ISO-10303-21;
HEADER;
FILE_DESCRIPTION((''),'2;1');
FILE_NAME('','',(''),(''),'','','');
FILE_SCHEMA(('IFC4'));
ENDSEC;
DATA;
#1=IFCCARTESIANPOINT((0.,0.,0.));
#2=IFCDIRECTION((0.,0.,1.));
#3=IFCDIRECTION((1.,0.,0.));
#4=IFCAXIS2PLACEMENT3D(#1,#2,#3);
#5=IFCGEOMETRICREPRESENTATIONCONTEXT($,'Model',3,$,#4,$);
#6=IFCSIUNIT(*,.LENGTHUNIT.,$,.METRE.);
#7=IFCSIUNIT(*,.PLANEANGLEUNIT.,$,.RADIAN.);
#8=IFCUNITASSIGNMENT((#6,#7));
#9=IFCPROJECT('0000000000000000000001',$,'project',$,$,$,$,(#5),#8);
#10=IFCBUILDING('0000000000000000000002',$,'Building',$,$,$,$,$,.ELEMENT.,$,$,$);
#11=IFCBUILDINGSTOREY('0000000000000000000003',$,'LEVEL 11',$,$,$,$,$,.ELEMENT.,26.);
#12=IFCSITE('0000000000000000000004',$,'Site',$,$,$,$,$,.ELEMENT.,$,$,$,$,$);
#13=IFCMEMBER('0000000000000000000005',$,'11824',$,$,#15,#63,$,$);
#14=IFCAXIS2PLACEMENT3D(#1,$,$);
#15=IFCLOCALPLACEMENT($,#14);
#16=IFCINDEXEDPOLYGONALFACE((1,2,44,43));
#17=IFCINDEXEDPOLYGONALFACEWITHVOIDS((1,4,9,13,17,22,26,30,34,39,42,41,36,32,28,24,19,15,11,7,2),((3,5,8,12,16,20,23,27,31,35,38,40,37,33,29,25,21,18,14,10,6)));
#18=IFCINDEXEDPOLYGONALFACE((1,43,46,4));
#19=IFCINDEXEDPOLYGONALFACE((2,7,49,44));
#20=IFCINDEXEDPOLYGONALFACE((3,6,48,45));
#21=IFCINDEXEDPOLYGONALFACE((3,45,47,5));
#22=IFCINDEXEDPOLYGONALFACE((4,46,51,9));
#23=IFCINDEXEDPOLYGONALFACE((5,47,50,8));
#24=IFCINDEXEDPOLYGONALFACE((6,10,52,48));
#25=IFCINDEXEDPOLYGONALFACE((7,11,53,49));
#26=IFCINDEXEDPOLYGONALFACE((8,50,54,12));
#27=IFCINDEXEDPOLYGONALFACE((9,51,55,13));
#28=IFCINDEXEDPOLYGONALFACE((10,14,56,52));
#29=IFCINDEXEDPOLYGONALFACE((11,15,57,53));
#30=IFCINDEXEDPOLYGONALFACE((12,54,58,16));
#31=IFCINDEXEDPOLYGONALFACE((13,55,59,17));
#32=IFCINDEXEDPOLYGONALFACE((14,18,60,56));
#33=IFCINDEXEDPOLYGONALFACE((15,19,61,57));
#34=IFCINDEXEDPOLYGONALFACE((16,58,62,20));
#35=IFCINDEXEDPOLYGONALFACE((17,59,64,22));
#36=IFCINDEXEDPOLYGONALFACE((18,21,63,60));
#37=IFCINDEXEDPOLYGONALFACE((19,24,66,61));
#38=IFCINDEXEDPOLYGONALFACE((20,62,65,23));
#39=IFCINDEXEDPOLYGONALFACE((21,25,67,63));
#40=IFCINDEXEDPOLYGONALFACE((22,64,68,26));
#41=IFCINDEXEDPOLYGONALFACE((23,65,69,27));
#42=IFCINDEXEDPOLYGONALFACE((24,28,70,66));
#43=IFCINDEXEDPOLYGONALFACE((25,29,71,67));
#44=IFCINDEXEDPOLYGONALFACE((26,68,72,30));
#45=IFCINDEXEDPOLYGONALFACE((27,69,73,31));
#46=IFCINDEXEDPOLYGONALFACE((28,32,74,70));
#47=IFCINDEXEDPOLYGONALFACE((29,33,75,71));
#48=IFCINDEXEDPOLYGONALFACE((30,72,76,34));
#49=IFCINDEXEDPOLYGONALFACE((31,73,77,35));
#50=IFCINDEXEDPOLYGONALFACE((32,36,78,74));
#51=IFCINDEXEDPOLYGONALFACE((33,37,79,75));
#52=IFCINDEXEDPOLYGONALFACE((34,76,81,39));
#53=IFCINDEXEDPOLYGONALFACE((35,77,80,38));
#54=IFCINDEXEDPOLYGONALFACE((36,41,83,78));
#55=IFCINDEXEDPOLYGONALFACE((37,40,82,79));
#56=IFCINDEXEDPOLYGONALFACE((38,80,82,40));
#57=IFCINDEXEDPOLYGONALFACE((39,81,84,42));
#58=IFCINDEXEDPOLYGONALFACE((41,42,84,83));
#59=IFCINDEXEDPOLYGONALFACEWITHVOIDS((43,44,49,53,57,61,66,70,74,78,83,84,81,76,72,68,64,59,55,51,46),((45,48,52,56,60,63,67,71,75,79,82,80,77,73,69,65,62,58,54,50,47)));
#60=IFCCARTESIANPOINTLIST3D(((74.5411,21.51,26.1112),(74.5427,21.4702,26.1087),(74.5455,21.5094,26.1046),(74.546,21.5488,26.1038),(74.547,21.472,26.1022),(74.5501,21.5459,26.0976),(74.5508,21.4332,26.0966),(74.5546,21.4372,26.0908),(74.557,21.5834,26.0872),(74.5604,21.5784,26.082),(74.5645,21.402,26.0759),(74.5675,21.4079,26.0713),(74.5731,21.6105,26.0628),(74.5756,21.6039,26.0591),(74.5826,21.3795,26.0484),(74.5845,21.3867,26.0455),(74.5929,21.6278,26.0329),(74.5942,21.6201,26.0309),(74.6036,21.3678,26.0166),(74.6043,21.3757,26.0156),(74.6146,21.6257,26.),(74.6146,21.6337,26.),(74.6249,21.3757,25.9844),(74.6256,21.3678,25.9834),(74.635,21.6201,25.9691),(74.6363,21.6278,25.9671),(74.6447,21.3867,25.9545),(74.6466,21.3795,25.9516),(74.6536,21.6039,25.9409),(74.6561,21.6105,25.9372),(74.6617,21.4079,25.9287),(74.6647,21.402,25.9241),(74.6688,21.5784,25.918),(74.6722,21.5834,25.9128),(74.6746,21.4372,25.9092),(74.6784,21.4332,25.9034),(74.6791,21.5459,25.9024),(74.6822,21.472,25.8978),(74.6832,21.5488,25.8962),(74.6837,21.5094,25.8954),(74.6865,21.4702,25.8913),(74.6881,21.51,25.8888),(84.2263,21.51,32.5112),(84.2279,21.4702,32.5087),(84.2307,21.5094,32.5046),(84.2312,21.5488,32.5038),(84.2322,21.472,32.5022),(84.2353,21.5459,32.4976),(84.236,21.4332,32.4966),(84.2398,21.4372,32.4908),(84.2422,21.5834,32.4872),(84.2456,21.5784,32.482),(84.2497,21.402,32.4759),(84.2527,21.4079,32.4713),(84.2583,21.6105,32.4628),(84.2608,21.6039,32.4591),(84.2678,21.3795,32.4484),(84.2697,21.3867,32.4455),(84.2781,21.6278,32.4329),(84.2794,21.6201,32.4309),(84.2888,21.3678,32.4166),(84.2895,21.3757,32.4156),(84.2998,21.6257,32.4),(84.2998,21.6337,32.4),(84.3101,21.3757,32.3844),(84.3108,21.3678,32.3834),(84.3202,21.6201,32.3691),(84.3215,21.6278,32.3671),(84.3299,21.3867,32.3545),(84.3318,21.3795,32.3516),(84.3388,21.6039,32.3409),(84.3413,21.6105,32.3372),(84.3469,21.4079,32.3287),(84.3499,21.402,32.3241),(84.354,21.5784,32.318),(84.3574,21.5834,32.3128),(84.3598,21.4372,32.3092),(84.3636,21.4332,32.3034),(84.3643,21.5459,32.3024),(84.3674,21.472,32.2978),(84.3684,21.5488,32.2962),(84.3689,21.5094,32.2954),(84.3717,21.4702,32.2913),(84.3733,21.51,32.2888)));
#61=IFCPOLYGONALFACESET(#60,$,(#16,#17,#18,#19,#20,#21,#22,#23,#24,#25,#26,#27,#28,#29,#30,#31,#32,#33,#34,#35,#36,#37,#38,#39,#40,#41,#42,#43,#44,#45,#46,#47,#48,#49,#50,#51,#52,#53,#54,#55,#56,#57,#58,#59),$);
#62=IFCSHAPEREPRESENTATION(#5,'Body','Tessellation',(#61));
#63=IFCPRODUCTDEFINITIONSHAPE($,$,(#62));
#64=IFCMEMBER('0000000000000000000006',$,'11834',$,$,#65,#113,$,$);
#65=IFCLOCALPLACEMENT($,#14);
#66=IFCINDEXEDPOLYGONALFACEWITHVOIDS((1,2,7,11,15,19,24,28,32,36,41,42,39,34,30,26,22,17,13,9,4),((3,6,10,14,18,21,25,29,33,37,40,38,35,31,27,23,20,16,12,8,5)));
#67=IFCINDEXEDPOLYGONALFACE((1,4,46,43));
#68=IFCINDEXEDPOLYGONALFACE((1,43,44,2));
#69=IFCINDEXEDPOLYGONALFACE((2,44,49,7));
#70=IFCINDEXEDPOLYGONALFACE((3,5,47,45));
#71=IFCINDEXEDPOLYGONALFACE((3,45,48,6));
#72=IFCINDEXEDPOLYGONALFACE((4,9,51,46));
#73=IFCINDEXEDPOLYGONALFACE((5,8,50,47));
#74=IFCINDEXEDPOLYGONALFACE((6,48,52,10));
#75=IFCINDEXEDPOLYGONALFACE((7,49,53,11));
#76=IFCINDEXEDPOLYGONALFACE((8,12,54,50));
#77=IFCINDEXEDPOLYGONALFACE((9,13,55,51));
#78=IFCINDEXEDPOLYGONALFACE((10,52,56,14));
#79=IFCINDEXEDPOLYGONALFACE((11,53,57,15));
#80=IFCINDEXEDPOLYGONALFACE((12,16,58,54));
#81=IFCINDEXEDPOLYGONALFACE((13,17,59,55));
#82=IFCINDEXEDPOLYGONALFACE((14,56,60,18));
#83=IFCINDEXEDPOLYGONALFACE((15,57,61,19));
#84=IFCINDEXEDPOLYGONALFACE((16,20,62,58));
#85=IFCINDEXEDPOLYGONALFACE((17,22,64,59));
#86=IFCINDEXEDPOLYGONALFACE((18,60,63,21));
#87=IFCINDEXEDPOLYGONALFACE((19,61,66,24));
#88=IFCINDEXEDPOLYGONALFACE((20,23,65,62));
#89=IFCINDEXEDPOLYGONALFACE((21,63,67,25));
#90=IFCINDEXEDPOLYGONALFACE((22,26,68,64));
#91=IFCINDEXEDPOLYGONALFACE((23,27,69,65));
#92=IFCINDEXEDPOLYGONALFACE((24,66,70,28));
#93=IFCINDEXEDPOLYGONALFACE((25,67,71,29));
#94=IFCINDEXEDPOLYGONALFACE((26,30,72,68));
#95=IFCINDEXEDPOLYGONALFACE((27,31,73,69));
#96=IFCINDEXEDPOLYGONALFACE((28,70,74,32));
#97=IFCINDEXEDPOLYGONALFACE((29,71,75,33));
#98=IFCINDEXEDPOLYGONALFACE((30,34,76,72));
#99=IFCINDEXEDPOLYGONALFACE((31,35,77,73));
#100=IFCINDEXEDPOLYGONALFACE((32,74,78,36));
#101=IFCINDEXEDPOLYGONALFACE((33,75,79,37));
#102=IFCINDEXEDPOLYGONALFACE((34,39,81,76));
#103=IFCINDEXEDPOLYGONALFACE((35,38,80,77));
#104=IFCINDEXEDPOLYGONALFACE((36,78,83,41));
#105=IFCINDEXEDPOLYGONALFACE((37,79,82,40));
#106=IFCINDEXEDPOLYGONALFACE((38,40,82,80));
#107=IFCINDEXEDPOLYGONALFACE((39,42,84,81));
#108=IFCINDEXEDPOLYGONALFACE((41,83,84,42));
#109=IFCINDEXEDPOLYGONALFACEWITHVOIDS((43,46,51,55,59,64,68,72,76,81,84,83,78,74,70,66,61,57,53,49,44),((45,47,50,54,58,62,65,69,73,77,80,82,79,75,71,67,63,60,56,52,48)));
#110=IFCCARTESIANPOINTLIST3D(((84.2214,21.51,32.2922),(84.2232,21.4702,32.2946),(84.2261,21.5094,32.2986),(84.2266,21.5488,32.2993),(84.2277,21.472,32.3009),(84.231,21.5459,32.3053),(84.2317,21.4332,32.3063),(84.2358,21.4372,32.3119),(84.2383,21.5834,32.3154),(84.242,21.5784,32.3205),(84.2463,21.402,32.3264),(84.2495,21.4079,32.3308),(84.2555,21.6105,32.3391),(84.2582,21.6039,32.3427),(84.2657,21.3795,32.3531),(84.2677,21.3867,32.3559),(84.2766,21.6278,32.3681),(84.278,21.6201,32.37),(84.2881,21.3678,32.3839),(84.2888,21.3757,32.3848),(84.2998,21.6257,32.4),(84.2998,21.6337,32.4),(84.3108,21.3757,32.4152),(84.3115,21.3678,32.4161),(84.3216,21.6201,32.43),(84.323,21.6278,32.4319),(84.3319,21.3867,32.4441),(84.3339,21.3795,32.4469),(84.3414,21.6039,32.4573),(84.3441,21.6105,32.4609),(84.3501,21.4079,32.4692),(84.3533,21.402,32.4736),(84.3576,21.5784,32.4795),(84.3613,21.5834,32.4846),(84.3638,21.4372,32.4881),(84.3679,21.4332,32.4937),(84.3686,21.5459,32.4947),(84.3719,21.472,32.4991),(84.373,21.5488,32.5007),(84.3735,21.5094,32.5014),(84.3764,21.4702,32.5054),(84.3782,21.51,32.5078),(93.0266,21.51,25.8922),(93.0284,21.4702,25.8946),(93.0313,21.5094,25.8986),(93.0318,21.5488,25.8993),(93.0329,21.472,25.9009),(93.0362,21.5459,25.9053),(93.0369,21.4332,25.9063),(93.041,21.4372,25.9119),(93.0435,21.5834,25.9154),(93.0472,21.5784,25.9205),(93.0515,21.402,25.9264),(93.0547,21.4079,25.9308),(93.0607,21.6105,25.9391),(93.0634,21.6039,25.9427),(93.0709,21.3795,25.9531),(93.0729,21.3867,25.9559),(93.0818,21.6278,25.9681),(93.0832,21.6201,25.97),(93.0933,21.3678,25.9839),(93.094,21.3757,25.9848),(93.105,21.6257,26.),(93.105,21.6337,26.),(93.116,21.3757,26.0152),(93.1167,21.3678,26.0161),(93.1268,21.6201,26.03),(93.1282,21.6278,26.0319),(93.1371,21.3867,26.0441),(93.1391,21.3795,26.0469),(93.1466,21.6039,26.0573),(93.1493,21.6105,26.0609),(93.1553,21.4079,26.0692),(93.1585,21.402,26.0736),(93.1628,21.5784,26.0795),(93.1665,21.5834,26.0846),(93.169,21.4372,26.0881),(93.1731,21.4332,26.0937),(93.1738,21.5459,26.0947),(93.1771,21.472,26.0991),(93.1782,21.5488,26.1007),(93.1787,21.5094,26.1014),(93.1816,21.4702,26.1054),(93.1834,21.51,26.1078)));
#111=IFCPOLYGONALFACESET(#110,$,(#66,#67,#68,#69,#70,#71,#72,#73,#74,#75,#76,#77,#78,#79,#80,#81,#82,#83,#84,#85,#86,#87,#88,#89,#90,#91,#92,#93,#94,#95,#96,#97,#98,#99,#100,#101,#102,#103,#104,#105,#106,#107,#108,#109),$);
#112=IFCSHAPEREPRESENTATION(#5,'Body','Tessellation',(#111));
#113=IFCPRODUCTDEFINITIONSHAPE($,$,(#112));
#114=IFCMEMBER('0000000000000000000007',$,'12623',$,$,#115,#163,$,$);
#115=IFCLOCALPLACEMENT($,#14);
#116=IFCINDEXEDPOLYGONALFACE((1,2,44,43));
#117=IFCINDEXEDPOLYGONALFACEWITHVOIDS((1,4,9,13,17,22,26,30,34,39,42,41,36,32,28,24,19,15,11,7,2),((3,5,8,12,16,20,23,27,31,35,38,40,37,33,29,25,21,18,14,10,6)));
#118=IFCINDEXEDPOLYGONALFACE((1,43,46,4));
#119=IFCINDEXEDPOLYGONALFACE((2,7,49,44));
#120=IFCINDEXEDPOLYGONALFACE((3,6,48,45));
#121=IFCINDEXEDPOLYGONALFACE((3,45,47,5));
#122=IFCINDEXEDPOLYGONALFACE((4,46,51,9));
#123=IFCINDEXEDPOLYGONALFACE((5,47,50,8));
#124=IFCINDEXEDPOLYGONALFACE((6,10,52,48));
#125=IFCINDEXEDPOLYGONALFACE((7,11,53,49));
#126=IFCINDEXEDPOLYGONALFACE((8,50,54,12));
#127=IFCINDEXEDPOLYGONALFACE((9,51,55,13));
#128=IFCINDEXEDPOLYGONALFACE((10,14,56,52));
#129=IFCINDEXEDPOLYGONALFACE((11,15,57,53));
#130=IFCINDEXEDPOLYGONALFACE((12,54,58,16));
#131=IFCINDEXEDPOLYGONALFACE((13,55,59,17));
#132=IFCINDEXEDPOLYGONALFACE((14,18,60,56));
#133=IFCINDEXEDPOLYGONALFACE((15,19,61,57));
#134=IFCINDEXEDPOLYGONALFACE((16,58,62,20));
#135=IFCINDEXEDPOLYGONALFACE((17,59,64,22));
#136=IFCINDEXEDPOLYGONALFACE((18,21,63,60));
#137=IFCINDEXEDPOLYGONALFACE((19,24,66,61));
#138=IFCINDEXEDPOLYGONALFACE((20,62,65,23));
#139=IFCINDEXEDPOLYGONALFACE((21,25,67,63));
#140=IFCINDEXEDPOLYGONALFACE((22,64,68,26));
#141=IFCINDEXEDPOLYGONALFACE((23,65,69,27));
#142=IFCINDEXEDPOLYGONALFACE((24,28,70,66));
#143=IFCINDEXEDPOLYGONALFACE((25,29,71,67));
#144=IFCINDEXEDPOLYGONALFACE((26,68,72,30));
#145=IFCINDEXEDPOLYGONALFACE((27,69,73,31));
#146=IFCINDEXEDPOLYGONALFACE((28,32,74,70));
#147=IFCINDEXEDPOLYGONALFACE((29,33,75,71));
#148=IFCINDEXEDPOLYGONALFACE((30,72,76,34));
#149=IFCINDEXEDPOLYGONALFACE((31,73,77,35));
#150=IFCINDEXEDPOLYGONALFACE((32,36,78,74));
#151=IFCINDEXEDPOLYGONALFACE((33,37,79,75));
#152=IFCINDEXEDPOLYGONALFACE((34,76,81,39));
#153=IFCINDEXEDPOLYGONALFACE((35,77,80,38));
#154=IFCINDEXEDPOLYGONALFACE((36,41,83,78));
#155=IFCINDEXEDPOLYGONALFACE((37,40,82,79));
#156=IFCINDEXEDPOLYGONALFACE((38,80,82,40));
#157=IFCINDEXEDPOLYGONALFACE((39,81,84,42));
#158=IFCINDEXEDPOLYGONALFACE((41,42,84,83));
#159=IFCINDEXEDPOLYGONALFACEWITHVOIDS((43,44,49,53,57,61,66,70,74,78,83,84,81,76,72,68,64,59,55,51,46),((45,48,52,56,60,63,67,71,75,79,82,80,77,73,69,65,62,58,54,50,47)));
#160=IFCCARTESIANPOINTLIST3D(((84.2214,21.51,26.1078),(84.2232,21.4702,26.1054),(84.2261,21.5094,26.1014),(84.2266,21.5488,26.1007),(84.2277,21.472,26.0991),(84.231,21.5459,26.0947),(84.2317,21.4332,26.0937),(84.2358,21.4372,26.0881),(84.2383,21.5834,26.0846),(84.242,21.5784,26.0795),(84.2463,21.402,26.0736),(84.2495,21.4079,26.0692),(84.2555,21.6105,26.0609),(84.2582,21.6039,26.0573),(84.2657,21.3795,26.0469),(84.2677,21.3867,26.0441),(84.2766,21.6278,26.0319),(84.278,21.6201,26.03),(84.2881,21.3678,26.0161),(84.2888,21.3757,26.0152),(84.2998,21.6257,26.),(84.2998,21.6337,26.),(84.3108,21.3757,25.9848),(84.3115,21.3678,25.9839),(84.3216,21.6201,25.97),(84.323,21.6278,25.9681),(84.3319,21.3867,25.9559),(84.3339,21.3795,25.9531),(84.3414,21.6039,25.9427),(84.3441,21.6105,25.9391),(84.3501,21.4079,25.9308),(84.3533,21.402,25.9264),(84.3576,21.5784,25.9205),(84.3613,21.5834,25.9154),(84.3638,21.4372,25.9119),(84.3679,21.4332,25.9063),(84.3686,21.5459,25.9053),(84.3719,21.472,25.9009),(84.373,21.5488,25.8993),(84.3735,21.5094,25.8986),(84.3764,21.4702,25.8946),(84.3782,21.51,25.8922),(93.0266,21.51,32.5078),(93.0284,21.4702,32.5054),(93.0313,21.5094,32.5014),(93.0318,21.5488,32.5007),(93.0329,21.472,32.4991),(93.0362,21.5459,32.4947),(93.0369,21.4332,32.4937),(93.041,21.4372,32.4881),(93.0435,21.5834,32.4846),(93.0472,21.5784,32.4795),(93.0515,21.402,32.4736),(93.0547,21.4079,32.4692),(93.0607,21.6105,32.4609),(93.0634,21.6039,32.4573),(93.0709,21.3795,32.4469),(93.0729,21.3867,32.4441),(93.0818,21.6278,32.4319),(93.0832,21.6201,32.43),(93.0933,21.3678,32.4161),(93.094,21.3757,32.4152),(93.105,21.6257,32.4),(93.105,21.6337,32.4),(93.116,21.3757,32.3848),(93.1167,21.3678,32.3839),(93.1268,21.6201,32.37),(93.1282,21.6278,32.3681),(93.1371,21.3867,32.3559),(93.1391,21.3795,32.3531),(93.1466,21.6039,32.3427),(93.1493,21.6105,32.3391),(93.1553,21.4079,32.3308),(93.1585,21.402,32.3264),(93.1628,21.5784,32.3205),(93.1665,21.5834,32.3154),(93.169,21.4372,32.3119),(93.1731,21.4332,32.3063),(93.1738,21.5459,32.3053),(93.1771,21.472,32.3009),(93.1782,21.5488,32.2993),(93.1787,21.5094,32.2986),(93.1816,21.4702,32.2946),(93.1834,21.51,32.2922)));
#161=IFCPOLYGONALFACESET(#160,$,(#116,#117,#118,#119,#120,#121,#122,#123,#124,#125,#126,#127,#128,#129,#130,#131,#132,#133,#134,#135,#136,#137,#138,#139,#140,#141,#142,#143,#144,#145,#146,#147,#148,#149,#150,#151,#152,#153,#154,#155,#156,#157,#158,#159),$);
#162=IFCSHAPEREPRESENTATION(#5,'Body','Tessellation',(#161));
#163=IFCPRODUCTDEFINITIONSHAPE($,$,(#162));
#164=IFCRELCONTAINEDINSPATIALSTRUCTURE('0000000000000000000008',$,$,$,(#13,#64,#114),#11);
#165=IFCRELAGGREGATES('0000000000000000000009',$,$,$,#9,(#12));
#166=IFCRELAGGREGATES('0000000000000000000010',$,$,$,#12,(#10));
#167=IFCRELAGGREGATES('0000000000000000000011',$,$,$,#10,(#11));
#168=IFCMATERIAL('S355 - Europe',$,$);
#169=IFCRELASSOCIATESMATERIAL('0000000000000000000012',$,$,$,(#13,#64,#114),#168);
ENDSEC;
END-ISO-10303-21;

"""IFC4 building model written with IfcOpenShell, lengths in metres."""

from ifc_helpers import new_model, si_unit, frame, origin_with_axes, origin_2d_with_axis, place, context, project, spatial, hollow_circle, extrude, material, material_profile, profile_set, profile_usage, element, save


model = new_model("IFC4")

# Units and contexts
model_context = context("Model", 3, world=origin_with_axes())
ifc_project = project(units=[si_unit("LENGTHUNIT", "METRE"), si_unit("PLANEANGLEUNIT", "RADIAN")], contexts=[model_context])

# Site, building, storey
site = spatial("IfcSite", under=ifc_project, Name="Site", CompositionType="ELEMENT")
building = spatial("IfcBuilding", under=site, Name="Building", CompositionType="ELEMENT")
storey = spatial("IfcBuildingStorey", under=building, Name="LEVEL 11", CompositionType="ELEMENT", Elevation=26.0)

# Shared definitions
ifc_material = material(Name="S355 - Europe")

# Members
ifc_material_profile_1 = material_profile(ifc_material, hollow_circle(Radius=0.1337, WallThickness=0.008, at=origin_2d_with_axis()))
ifc_profile_set_1 = profile_set([ifc_material_profile_1])
ifc_profile_usage_1 = profile_usage(ifc_profile_set_1, cardinal=10)
member_1_placement = place(None, frame((74.6146, 21.5, 26.0), z_axis=(0.834302, 0.0, 0.551308), x_axis=(0.0, 1.0, 0.0)))
element("IfcMember", 1, at=member_1_placement, inside=storey, material=ifc_profile_usage_1, Name="11824", context=model_context, shape_type="SweptSolid", body=[
    extrude(hollow_circle(Radius=0.1337, WallThickness=0.008, at=origin_2d_with_axis()), origin_with_axes(), (0.0, 0.0, 1.0), 11.6088),
])
ifc_material_profile_2 = material_profile(ifc_material, hollow_circle(Radius=0.1337, WallThickness=0.008, at=origin_2d_with_axis()))
ifc_profile_set_2 = profile_set([ifc_material_profile_2])
ifc_profile_usage_2 = profile_usage(ifc_profile_set_2, cardinal=10)
member_2_placement = place(None, frame((84.2998, 21.5, 32.4), z_axis=(0.808901, 0.0, -0.587944), x_axis=(0.0, 1.0, 0.0)))
element("IfcMember", 2, at=member_2_placement, inside=storey, material=ifc_profile_usage_2, Name="11834", context=model_context, shape_type="SweptSolid", body=[
    extrude(hollow_circle(Radius=0.1337, WallThickness=0.008, at=origin_2d_with_axis()), origin_with_axes(), (0.0, 0.0, 1.0), 10.8854),
])
ifc_material_profile_3 = material_profile(ifc_material, hollow_circle(Radius=0.1337, WallThickness=0.008, at=origin_2d_with_axis()))
ifc_profile_set_3 = profile_set([ifc_material_profile_3])
ifc_profile_usage_3 = profile_usage(ifc_profile_set_3, cardinal=10)
member_3_placement = place(None, frame((84.2998, 21.5, 26.0), z_axis=(0.808901, 0.0, 0.587944), x_axis=(0.0, 1.0, 0.0)))
element("IfcMember", 3, at=member_3_placement, inside=storey, material=ifc_profile_usage_3, Name="12623", context=model_context, shape_type="SweptSolid", body=[
    extrude(hollow_circle(Radius=0.1337, WallThickness=0.008, at=origin_2d_with_axis()), origin_with_axes(), (0.0, 0.0, 1.0), 10.8854),
])

save(model, "model.ifc")
